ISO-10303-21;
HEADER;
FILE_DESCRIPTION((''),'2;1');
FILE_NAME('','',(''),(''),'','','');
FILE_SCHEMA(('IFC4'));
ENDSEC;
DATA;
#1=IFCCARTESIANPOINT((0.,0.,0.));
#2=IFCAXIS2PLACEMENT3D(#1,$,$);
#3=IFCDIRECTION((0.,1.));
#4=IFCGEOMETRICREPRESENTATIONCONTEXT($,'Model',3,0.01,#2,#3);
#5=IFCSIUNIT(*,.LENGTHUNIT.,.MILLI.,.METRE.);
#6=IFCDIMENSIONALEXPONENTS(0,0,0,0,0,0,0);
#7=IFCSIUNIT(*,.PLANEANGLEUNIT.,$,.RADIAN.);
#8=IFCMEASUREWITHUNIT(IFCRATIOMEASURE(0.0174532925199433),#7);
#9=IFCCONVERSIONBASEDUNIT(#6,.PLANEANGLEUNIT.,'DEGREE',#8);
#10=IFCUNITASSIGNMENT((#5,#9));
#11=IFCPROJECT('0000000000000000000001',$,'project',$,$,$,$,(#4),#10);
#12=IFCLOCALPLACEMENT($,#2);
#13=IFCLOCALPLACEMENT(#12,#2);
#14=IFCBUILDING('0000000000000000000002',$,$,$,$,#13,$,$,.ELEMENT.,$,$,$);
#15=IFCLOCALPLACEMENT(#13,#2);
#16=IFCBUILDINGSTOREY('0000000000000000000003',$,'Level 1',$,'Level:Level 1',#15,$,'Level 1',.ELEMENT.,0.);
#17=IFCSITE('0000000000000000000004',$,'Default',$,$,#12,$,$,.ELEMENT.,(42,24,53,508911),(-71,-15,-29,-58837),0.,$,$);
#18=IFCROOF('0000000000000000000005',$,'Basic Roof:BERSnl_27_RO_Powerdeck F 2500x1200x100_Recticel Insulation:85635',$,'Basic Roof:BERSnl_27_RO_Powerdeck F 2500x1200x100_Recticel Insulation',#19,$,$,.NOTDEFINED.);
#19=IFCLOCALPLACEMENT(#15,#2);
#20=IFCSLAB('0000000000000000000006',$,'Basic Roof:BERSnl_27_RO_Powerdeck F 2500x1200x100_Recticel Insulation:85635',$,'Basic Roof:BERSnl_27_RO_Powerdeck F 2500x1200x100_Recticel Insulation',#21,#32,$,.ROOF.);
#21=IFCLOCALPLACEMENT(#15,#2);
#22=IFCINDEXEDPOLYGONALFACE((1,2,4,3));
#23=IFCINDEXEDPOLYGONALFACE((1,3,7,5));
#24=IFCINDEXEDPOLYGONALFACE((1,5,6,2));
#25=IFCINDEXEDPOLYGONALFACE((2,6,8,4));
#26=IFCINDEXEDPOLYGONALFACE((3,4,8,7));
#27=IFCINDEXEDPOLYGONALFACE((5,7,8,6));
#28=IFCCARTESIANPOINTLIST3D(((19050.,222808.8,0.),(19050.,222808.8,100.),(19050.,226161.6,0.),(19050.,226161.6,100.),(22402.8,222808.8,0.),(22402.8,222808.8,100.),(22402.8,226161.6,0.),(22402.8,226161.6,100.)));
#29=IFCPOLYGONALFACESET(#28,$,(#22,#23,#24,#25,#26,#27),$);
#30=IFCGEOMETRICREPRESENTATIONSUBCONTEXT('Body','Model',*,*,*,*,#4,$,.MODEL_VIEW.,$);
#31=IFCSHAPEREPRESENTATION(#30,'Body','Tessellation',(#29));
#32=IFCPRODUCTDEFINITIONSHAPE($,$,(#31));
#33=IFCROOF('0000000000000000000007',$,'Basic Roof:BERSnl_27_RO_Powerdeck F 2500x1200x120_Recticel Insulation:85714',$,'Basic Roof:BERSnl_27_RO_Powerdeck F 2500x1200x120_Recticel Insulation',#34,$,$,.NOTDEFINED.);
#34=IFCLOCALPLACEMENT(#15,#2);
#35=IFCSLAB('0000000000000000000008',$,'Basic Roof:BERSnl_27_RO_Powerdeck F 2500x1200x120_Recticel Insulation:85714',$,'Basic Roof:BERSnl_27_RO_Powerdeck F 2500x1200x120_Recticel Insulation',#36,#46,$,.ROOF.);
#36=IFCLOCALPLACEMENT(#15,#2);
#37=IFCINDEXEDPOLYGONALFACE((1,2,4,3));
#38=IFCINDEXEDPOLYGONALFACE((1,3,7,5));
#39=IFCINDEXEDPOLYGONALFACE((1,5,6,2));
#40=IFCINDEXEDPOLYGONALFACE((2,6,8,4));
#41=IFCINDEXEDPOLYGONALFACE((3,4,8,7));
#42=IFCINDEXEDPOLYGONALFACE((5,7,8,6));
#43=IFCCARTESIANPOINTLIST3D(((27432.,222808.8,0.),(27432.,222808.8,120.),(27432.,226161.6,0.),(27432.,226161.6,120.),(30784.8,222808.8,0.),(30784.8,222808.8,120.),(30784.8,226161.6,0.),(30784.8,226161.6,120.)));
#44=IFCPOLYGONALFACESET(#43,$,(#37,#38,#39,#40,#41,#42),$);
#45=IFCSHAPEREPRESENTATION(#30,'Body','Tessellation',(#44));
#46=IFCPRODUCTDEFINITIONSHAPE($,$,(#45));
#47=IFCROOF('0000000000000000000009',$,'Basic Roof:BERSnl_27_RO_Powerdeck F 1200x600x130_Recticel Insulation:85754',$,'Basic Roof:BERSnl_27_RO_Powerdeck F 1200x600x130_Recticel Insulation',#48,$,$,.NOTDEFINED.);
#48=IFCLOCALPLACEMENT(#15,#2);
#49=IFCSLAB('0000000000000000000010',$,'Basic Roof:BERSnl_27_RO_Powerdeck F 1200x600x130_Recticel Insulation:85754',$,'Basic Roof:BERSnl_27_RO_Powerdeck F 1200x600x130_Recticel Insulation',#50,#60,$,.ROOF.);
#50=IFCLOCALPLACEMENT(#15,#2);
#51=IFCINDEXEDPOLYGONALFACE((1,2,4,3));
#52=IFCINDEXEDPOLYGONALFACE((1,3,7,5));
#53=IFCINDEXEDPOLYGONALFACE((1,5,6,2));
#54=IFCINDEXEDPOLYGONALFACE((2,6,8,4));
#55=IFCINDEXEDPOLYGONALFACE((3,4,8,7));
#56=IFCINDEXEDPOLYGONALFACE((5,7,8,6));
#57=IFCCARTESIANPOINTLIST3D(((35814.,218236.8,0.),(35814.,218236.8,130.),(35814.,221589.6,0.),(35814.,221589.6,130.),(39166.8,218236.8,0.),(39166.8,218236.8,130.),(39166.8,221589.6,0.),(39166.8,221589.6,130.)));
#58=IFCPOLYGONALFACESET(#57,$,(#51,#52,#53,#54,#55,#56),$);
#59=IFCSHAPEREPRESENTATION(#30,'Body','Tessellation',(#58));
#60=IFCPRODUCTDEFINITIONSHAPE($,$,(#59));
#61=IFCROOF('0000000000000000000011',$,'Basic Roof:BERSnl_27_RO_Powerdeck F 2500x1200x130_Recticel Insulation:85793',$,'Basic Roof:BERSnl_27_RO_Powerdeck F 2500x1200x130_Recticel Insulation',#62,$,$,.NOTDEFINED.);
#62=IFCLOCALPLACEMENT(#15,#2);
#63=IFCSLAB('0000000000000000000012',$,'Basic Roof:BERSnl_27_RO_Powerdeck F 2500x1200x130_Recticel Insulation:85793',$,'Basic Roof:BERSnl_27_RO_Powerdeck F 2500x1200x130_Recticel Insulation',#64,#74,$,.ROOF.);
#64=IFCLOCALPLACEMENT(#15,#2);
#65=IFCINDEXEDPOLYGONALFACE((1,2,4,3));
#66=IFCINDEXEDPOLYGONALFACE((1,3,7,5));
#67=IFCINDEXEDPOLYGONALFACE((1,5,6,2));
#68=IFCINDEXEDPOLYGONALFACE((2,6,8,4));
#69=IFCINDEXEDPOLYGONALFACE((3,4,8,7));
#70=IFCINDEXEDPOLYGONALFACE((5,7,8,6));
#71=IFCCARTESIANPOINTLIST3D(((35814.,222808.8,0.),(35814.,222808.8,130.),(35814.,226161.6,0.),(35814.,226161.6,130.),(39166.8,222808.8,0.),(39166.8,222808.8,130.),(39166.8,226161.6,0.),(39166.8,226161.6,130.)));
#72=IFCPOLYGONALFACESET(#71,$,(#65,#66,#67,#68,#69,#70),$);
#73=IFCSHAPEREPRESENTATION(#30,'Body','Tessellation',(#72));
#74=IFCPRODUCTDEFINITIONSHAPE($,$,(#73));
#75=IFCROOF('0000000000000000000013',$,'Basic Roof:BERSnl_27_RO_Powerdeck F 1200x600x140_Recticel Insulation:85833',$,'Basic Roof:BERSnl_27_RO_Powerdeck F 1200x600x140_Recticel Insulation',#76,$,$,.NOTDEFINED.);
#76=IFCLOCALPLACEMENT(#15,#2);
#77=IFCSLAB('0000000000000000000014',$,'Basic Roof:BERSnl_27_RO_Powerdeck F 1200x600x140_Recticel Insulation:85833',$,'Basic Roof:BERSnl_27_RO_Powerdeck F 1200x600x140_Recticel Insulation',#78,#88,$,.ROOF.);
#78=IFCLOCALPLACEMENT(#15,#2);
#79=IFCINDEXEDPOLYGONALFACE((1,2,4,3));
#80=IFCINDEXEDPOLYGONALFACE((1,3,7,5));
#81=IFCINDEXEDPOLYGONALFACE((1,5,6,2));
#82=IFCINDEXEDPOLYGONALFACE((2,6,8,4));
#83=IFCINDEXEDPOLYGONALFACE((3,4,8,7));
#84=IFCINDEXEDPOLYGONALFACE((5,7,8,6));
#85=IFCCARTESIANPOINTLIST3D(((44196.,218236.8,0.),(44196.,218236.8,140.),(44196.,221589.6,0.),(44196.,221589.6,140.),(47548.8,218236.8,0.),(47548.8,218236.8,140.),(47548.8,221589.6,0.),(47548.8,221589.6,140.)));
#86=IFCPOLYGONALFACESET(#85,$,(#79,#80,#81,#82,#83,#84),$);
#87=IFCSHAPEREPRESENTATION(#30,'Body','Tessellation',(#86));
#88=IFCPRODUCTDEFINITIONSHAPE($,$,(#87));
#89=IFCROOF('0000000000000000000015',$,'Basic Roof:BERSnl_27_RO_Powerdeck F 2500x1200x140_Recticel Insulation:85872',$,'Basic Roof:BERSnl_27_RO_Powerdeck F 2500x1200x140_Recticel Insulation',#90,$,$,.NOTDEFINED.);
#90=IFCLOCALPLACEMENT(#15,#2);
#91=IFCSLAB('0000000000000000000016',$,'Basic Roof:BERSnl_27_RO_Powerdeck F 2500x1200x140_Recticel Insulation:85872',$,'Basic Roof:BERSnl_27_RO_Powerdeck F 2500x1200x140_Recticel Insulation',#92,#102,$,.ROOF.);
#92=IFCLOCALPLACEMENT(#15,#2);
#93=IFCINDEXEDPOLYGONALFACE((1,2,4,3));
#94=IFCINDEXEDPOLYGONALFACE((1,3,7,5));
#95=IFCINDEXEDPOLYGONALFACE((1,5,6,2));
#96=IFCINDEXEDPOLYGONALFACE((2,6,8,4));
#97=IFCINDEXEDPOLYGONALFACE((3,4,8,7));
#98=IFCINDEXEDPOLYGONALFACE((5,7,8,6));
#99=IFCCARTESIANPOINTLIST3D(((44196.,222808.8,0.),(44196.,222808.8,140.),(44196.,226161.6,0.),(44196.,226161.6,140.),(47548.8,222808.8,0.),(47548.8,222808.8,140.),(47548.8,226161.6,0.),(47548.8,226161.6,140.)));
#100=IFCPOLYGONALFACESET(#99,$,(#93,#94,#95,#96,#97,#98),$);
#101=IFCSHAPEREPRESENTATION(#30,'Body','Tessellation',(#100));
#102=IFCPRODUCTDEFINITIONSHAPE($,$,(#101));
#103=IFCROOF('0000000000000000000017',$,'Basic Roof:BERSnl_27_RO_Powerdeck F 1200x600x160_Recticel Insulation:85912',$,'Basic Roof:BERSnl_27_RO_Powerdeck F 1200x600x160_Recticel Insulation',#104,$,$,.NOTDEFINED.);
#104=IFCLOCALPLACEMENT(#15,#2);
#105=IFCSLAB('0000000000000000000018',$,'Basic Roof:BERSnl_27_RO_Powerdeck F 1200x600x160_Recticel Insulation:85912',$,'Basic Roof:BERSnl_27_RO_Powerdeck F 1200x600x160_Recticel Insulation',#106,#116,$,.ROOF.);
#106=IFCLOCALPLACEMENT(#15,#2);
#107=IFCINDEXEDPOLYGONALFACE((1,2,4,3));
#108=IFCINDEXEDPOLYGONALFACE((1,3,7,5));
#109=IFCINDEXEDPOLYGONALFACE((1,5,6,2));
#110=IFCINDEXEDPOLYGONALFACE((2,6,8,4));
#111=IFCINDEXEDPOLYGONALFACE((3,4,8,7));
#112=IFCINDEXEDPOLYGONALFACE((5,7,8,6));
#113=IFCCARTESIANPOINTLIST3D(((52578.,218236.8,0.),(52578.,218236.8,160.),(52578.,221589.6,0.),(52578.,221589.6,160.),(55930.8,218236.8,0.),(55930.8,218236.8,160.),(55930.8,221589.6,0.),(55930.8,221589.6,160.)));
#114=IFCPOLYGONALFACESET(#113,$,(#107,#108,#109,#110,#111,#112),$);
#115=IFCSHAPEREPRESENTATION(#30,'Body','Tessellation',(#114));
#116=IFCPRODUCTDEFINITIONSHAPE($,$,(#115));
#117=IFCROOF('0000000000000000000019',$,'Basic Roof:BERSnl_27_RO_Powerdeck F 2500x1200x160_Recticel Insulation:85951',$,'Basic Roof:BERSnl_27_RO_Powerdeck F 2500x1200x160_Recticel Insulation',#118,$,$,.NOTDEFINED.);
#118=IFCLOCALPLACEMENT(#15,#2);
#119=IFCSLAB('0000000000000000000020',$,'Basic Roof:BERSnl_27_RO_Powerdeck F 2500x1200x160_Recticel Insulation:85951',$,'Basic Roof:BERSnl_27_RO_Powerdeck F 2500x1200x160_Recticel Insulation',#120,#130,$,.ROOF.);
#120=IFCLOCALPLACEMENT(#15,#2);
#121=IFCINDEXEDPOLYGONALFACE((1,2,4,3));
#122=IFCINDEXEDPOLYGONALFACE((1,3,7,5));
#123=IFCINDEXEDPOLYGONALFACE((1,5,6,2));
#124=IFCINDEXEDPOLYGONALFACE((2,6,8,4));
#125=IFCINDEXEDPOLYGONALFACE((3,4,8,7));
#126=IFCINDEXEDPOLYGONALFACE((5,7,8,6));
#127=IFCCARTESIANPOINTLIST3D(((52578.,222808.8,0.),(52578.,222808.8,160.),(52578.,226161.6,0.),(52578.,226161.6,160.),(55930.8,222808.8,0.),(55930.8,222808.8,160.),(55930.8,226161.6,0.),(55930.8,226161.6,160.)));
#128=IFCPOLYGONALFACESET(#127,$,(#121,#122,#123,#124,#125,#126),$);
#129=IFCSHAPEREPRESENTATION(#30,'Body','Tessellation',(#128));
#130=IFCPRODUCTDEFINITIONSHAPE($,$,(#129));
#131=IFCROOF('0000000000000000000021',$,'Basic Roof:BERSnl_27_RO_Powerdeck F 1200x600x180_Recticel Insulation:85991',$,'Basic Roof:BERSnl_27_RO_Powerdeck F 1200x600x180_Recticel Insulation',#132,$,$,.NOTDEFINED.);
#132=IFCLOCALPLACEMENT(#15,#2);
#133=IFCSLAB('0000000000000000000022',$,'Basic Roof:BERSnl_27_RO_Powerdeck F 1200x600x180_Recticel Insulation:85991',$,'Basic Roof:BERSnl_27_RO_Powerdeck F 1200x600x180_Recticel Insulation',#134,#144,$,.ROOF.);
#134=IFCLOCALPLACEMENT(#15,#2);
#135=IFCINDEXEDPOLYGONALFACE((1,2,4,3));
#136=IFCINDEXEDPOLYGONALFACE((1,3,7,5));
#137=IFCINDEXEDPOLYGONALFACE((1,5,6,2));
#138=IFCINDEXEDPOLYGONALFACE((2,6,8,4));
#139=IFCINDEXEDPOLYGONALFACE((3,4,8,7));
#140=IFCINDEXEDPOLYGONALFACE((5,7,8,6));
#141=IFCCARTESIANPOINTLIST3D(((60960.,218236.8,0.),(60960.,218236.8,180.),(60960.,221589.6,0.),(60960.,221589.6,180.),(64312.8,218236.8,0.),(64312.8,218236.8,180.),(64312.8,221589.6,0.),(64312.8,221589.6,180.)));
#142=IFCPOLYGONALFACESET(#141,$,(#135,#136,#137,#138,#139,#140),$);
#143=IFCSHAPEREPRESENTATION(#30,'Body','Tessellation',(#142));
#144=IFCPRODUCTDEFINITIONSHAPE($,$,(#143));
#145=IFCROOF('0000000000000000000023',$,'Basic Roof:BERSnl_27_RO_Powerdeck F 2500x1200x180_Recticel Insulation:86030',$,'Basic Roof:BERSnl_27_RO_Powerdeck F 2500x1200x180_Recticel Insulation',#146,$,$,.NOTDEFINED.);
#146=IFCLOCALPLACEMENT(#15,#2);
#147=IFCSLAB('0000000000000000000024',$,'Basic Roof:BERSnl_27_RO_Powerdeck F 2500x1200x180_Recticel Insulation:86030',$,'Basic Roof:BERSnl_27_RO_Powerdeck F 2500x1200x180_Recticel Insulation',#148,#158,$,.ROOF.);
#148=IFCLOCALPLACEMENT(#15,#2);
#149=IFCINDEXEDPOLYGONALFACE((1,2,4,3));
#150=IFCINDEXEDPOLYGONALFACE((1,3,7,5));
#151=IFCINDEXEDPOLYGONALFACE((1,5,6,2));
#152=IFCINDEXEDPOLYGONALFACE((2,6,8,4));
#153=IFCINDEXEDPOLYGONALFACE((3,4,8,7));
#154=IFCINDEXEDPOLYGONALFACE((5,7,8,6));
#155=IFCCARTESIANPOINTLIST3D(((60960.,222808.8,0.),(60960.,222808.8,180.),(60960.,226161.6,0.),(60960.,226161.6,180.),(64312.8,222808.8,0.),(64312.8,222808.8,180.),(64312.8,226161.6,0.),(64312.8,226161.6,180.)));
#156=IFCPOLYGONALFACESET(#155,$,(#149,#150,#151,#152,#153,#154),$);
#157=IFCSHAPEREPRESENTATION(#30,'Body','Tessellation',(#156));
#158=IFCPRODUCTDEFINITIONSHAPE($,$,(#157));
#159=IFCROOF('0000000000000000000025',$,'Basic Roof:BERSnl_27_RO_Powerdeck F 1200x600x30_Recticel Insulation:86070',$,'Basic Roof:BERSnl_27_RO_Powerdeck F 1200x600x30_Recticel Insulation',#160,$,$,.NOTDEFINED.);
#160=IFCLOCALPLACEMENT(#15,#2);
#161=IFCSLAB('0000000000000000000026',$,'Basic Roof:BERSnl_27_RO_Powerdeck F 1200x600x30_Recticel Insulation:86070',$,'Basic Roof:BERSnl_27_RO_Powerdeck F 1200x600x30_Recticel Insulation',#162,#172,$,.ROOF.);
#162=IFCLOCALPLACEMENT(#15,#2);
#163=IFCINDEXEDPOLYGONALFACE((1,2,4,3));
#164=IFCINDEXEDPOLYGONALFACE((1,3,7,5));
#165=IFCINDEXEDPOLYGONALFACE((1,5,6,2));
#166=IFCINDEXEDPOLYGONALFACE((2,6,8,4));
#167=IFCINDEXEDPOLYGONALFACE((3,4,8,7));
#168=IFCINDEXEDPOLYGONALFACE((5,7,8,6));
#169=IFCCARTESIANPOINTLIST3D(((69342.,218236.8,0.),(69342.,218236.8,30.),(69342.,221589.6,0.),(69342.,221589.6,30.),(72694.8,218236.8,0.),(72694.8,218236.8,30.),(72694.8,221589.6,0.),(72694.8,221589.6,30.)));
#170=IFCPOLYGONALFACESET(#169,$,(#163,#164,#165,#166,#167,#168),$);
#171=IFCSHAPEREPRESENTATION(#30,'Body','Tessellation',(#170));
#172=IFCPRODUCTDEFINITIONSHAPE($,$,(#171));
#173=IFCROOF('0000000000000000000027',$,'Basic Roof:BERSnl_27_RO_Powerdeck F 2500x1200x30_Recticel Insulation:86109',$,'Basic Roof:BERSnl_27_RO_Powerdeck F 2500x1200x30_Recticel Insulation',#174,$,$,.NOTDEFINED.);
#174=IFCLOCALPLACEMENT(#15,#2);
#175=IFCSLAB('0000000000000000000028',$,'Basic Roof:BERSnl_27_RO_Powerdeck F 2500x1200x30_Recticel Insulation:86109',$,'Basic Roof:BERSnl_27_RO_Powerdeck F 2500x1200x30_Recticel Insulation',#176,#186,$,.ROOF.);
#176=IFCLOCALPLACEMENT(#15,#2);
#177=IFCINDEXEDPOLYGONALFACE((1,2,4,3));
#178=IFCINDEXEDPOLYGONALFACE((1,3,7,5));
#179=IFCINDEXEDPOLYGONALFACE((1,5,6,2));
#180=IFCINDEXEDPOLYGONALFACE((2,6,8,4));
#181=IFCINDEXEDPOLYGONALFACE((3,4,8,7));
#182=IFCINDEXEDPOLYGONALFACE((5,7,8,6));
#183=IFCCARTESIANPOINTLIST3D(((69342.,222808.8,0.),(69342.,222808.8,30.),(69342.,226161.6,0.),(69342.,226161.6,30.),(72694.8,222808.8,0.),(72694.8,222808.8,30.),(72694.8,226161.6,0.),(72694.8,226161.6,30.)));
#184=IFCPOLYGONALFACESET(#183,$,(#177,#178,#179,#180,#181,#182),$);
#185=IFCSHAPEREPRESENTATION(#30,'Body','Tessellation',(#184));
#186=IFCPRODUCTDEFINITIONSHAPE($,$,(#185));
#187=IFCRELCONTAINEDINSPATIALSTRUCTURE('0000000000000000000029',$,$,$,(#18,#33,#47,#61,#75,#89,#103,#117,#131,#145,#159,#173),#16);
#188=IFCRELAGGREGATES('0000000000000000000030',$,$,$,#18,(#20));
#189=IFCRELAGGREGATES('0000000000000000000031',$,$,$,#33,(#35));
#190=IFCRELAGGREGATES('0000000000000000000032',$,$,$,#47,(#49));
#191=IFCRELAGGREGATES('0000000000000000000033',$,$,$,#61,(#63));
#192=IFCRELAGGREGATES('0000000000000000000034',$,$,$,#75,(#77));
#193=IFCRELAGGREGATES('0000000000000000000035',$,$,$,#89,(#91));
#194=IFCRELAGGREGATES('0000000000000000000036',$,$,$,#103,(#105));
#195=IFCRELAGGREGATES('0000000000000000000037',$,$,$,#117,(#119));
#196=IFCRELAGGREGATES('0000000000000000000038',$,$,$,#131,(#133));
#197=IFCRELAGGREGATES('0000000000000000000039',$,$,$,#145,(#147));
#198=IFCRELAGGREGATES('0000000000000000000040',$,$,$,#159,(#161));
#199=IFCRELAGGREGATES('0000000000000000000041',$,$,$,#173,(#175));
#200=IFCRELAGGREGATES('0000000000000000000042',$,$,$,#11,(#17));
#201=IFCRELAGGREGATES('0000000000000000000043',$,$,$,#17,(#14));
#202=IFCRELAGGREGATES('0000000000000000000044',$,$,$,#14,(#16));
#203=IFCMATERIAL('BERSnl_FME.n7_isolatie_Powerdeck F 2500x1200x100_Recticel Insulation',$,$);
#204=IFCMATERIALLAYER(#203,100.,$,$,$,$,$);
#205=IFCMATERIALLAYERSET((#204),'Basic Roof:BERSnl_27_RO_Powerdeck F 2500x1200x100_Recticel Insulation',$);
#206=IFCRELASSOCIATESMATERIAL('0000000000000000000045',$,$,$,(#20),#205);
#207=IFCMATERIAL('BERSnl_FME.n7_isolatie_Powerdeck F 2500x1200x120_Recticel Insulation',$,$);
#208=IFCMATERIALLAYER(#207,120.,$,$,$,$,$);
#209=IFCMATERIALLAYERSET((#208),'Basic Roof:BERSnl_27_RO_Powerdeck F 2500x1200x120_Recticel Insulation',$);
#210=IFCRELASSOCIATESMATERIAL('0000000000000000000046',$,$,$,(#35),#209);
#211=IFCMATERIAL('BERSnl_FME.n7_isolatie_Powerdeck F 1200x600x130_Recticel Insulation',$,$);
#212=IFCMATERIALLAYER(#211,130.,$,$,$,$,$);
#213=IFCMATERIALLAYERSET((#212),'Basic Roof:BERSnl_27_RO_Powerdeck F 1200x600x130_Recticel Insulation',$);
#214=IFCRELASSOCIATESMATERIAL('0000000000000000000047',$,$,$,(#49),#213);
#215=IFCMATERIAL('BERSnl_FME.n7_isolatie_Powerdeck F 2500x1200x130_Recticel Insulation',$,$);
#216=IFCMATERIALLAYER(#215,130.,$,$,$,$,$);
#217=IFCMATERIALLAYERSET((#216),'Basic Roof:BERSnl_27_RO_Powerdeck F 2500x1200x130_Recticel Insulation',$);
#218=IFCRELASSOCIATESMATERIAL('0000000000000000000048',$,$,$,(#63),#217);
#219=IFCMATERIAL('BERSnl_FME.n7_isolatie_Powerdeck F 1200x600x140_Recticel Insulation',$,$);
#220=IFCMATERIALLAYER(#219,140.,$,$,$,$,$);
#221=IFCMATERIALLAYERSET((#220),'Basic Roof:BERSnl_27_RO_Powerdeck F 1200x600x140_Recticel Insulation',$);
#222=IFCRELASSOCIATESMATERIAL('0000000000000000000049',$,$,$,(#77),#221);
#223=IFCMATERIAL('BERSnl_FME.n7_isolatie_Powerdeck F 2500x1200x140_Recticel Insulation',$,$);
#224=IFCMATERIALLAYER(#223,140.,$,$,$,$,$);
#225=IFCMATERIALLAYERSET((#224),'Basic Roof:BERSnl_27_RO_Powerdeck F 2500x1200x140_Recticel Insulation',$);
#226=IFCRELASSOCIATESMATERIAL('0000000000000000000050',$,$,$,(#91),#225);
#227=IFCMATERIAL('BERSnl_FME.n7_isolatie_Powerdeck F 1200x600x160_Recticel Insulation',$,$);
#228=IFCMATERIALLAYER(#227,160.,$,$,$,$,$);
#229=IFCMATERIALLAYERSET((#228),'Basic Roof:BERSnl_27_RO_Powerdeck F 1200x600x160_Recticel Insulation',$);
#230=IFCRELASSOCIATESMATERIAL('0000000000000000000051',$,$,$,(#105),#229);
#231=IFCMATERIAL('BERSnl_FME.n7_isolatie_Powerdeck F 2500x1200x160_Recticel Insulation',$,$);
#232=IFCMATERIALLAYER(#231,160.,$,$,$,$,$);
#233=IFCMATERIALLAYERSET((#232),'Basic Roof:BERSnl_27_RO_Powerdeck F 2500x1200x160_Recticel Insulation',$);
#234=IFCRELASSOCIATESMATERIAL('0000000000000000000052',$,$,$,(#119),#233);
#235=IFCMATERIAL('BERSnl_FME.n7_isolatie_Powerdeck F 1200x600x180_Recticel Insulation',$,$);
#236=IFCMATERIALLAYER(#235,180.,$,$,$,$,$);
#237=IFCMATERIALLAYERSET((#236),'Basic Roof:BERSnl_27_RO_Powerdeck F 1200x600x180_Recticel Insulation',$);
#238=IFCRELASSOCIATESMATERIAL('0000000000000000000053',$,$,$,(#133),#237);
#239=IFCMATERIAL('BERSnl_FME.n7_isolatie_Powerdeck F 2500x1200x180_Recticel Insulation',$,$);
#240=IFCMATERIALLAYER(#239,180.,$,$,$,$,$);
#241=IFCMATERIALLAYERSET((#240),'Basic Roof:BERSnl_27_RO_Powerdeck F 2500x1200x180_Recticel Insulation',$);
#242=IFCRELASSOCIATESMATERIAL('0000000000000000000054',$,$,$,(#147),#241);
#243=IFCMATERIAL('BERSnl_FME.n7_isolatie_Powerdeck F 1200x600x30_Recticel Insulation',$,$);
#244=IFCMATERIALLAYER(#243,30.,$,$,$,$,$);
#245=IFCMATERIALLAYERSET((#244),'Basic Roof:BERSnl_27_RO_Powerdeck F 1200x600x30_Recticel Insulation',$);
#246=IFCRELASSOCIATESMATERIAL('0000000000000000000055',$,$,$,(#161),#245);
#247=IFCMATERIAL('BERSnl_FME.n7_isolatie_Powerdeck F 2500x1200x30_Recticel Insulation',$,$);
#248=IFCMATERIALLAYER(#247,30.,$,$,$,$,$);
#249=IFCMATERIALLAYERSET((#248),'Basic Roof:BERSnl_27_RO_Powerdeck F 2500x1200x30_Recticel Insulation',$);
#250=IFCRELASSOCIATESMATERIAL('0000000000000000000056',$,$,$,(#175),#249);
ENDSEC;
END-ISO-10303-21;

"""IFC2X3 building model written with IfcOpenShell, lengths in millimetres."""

from ifc_helpers import new_model, entity, si_unit, converted_unit, direction, frame, frame_2d, origin, place, context, subcontext, project, spatial, rectangle, extrude, material, layer, layer_set, element, aggregate, save


model = new_model("IFC2X3")

# Units and contexts
model_context = context("Model", 3, precision=0.01, world=origin(), true_north=direction((0.0, 1.0)))
body_context = subcontext(model_context, "Body", "Model", "MODEL_VIEW")
ifc_project = project(units=[si_unit("LENGTHUNIT", "METRE", prefix="MILLI"), converted_unit("PLANEANGLEUNIT", "DEGREE", entity("IfcRatioMeasure", 0.0174532925199433), si_unit("PLANEANGLEUNIT", "RADIAN"), dimensions=[0, 0, 0, 0, 0, 0, 0])], contexts=[model_context])

# Site, building, storey
site_placement = place(None, origin())
site = spatial("IfcSite", under=ifc_project, at=site_placement, Name="Default", CompositionType="ELEMENT", RefLatitude=(42, 24, 53, 508911), RefLongitude=(-71, -15, -29, -58837), RefElevation=0.0)
building_placement = place(site_placement, origin())
building = spatial("IfcBuilding", under=site, at=building_placement, CompositionType="ELEMENT")
storey_placement = place(building_placement, origin())
storey = spatial("IfcBuildingStorey", under=building, at=storey_placement, Name="Level 1", ObjectType="Level:Level 1", LongName="Level 1", CompositionType="ELEMENT", Elevation=0.0)

# Roofs, slabs
roof_1_placement = place(storey_placement, frame((19050.0, 222808.8, 0.0)))
roof_1 = element("IfcRoof", 1, at=roof_1_placement, inside=storey, Name="Basic Roof:BERSnl_27_RO_Powerdeck F 2500x1200x100_Recticel Insulation:85635", ObjectType="Basic Roof:BERSnl_27_RO_Powerdeck F 2500x1200x100_Recticel Insulation", ShapeType="NOTDEFINED")
ifc_material_1 = material(Name="BERSnl_FME.n7_isolatie_Powerdeck F 2500x1200x100_Recticel Insulation")
ifc_layer_1 = layer(ifc_material_1, 100.0)
ifc_layer_set_1 = layer_set([ifc_layer_1], Name="Basic Roof:BERSnl_27_RO_Powerdeck F 2500x1200x100_Recticel Insulation")
slab_1_placement = place(roof_1_placement, origin())
slab_1 = element("IfcSlab", 2, at=slab_1_placement, material=ifc_layer_set_1, Name="Basic Roof:BERSnl_27_RO_Powerdeck F 2500x1200x100_Recticel Insulation:85635", ObjectType="Basic Roof:BERSnl_27_RO_Powerdeck F 2500x1200x100_Recticel Insulation", PredefinedType="ROOF", context=body_context, shape_type="SweptSolid", body=[
    extrude(rectangle(XDim=3352.8, YDim=3352.8, at=frame_2d((0.0, 0.0), x_axis=(-1.0, 0.0))), frame((1676.4, 1676.4, 0.0)), (0.0, 0.0, 1.0), 100.0),
])
aggregate(roof_1, [slab_1])
roof_2_placement = place(storey_placement, frame((27432.0, 222808.8, 0.0)))
roof_2 = element("IfcRoof", 3, at=roof_2_placement, inside=storey, Name="Basic Roof:BERSnl_27_RO_Powerdeck F 2500x1200x120_Recticel Insulation:85714", ObjectType="Basic Roof:BERSnl_27_RO_Powerdeck F 2500x1200x120_Recticel Insulation", ShapeType="NOTDEFINED")
ifc_material_2 = material(Name="BERSnl_FME.n7_isolatie_Powerdeck F 2500x1200x120_Recticel Insulation")
ifc_layer_2 = layer(ifc_material_2, 120.0)
ifc_layer_set_2 = layer_set([ifc_layer_2], Name="Basic Roof:BERSnl_27_RO_Powerdeck F 2500x1200x120_Recticel Insulation")
slab_2_placement = place(roof_2_placement, origin())
slab_2 = element("IfcSlab", 4, at=slab_2_placement, material=ifc_layer_set_2, Name="Basic Roof:BERSnl_27_RO_Powerdeck F 2500x1200x120_Recticel Insulation:85714", ObjectType="Basic Roof:BERSnl_27_RO_Powerdeck F 2500x1200x120_Recticel Insulation", PredefinedType="ROOF", context=body_context, shape_type="SweptSolid", body=[
    extrude(rectangle(XDim=3352.8, YDim=3352.8, at=frame_2d((0.0, 0.0), x_axis=(-1.0, 0.0))), frame((1676.4, 1676.4, 0.0)), (0.0, 0.0, 1.0), 120.0),
])
aggregate(roof_2, [slab_2])
roof_3_placement = place(storey_placement, frame((35814.0, 218236.8, 0.0)))
roof_3 = element("IfcRoof", 5, at=roof_3_placement, inside=storey, Name="Basic Roof:BERSnl_27_RO_Powerdeck F 1200x600x130_Recticel Insulation:85754", ObjectType="Basic Roof:BERSnl_27_RO_Powerdeck F 1200x600x130_Recticel Insulation", ShapeType="NOTDEFINED")
ifc_material_3 = material(Name="BERSnl_FME.n7_isolatie_Powerdeck F 1200x600x130_Recticel Insulation")
ifc_layer_3 = layer(ifc_material_3, 130.0)
ifc_layer_set_3 = layer_set([ifc_layer_3], Name="Basic Roof:BERSnl_27_RO_Powerdeck F 1200x600x130_Recticel Insulation")
slab_3_placement = place(roof_3_placement, origin())
slab_3 = element("IfcSlab", 6, at=slab_3_placement, material=ifc_layer_set_3, Name="Basic Roof:BERSnl_27_RO_Powerdeck F 1200x600x130_Recticel Insulation:85754", ObjectType="Basic Roof:BERSnl_27_RO_Powerdeck F 1200x600x130_Recticel Insulation", PredefinedType="ROOF", context=body_context, shape_type="SweptSolid", body=[
    extrude(rectangle(XDim=3352.8, YDim=3352.8, at=frame_2d((0.0, 0.0), x_axis=(-1.0, 0.0))), frame((1676.4, 1676.4, 0.0)), (0.0, 0.0, 1.0), 130.0),
])
aggregate(roof_3, [slab_3])
roof_4_placement = place(storey_placement, frame((35814.0, 222808.8, 0.0)))
roof_4 = element("IfcRoof", 7, at=roof_4_placement, inside=storey, Name="Basic Roof:BERSnl_27_RO_Powerdeck F 2500x1200x130_Recticel Insulation:85793", ObjectType="Basic Roof:BERSnl_27_RO_Powerdeck F 2500x1200x130_Recticel Insulation", ShapeType="NOTDEFINED")
ifc_material_4 = material(Name="BERSnl_FME.n7_isolatie_Powerdeck F 2500x1200x130_Recticel Insulation")
ifc_layer_4 = layer(ifc_material_4, 130.0)
ifc_layer_set_4 = layer_set([ifc_layer_4], Name="Basic Roof:BERSnl_27_RO_Powerdeck F 2500x1200x130_Recticel Insulation")
slab_4_placement = place(roof_4_placement, origin())
slab_4 = element("IfcSlab", 8, at=slab_4_placement, material=ifc_layer_set_4, Name="Basic Roof:BERSnl_27_RO_Powerdeck F 2500x1200x130_Recticel Insulation:85793", ObjectType="Basic Roof:BERSnl_27_RO_Powerdeck F 2500x1200x130_Recticel Insulation", PredefinedType="ROOF", context=body_context, shape_type="SweptSolid", body=[
    extrude(rectangle(XDim=3352.8, YDim=3352.8, at=frame_2d((0.0, 0.0), x_axis=(-1.0, 0.0))), frame((1676.4, 1676.4, 0.0)), (0.0, 0.0, 1.0), 130.0),
])
aggregate(roof_4, [slab_4])
roof_5_placement = place(storey_placement, frame((44196.0, 218236.8, 0.0)))
roof_5 = element("IfcRoof", 9, at=roof_5_placement, inside=storey, Name="Basic Roof:BERSnl_27_RO_Powerdeck F 1200x600x140_Recticel Insulation:85833", ObjectType="Basic Roof:BERSnl_27_RO_Powerdeck F 1200x600x140_Recticel Insulation", ShapeType="NOTDEFINED")
ifc_material_5 = material(Name="BERSnl_FME.n7_isolatie_Powerdeck F 1200x600x140_Recticel Insulation")
ifc_layer_5 = layer(ifc_material_5, 140.0)
ifc_layer_set_5 = layer_set([ifc_layer_5], Name="Basic Roof:BERSnl_27_RO_Powerdeck F 1200x600x140_Recticel Insulation")
slab_5_placement = place(roof_5_placement, origin())
slab_5 = element("IfcSlab", 10, at=slab_5_placement, material=ifc_layer_set_5, Name="Basic Roof:BERSnl_27_RO_Powerdeck F 1200x600x140_Recticel Insulation:85833", ObjectType="Basic Roof:BERSnl_27_RO_Powerdeck F 1200x600x140_Recticel Insulation", PredefinedType="ROOF", context=body_context, shape_type="SweptSolid", body=[
    extrude(rectangle(XDim=3352.8, YDim=3352.8, at=frame_2d((0.0, 0.0), x_axis=(-1.0, 0.0))), frame((1676.4, 1676.4, 0.0)), (0.0, 0.0, 1.0), 140.0),
])
aggregate(roof_5, [slab_5])
roof_6_placement = place(storey_placement, frame((44196.0, 222808.8, 0.0)))
roof_6 = element("IfcRoof", 11, at=roof_6_placement, inside=storey, Name="Basic Roof:BERSnl_27_RO_Powerdeck F 2500x1200x140_Recticel Insulation:85872", ObjectType="Basic Roof:BERSnl_27_RO_Powerdeck F 2500x1200x140_Recticel Insulation", ShapeType="NOTDEFINED")
ifc_material_6 = material(Name="BERSnl_FME.n7_isolatie_Powerdeck F 2500x1200x140_Recticel Insulation")
ifc_layer_6 = layer(ifc_material_6, 140.0)
ifc_layer_set_6 = layer_set([ifc_layer_6], Name="Basic Roof:BERSnl_27_RO_Powerdeck F 2500x1200x140_Recticel Insulation")
slab_6_placement = place(roof_6_placement, origin())
slab_6 = element("IfcSlab", 12, at=slab_6_placement, material=ifc_layer_set_6, Name="Basic Roof:BERSnl_27_RO_Powerdeck F 2500x1200x140_Recticel Insulation:85872", ObjectType="Basic Roof:BERSnl_27_RO_Powerdeck F 2500x1200x140_Recticel Insulation", PredefinedType="ROOF", context=body_context, shape_type="SweptSolid", body=[
    extrude(rectangle(XDim=3352.8, YDim=3352.8, at=frame_2d((0.0, 0.0), x_axis=(-1.0, 0.0))), frame((1676.4, 1676.4, 0.0)), (0.0, 0.0, 1.0), 140.0),
])
aggregate(roof_6, [slab_6])
roof_7_placement = place(storey_placement, frame((52578.0, 218236.8, 0.0)))
roof_7 = element("IfcRoof", 13, at=roof_7_placement, inside=storey, Name="Basic Roof:BERSnl_27_RO_Powerdeck F 1200x600x160_Recticel Insulation:85912", ObjectType="Basic Roof:BERSnl_27_RO_Powerdeck F 1200x600x160_Recticel Insulation", ShapeType="NOTDEFINED")
ifc_material_7 = material(Name="BERSnl_FME.n7_isolatie_Powerdeck F 1200x600x160_Recticel Insulation")
ifc_layer_7 = layer(ifc_material_7, 160.0)
ifc_layer_set_7 = layer_set([ifc_layer_7], Name="Basic Roof:BERSnl_27_RO_Powerdeck F 1200x600x160_Recticel Insulation")
slab_7_placement = place(roof_7_placement, origin())
slab_7 = element("IfcSlab", 14, at=slab_7_placement, material=ifc_layer_set_7, Name="Basic Roof:BERSnl_27_RO_Powerdeck F 1200x600x160_Recticel Insulation:85912", ObjectType="Basic Roof:BERSnl_27_RO_Powerdeck F 1200x600x160_Recticel Insulation", PredefinedType="ROOF", context=body_context, shape_type="SweptSolid", body=[
    extrude(rectangle(XDim=3352.8, YDim=3352.8, at=frame_2d((0.0, 0.0), x_axis=(-1.0, 0.0))), frame((1676.4, 1676.4, 0.0)), (0.0, 0.0, 1.0), 160.0),
])
aggregate(roof_7, [slab_7])
roof_8_placement = place(storey_placement, frame((52578.0, 222808.8, 0.0)))
roof_8 = element("IfcRoof", 15, at=roof_8_placement, inside=storey, Name="Basic Roof:BERSnl_27_RO_Powerdeck F 2500x1200x160_Recticel Insulation:85951", ObjectType="Basic Roof:BERSnl_27_RO_Powerdeck F 2500x1200x160_Recticel Insulation", ShapeType="NOTDEFINED")
ifc_material_8 = material(Name="BERSnl_FME.n7_isolatie_Powerdeck F 2500x1200x160_Recticel Insulation")
ifc_layer_8 = layer(ifc_material_8, 160.0)
ifc_layer_set_8 = layer_set([ifc_layer_8], Name="Basic Roof:BERSnl_27_RO_Powerdeck F 2500x1200x160_Recticel Insulation")
slab_8_placement = place(roof_8_placement, origin())
slab_8 = element("IfcSlab", 16, at=slab_8_placement, material=ifc_layer_set_8, Name="Basic Roof:BERSnl_27_RO_Powerdeck F 2500x1200x160_Recticel Insulation:85951", ObjectType="Basic Roof:BERSnl_27_RO_Powerdeck F 2500x1200x160_Recticel Insulation", PredefinedType="ROOF", context=body_context, shape_type="SweptSolid", body=[
    extrude(rectangle(XDim=3352.8, YDim=3352.8, at=frame_2d((0.0, 0.0), x_axis=(-1.0, 0.0))), frame((1676.4, 1676.4, 0.0)), (0.0, 0.0, 1.0), 160.0),
])
aggregate(roof_8, [slab_8])
roof_9_placement = place(storey_placement, frame((60960.0, 218236.8, 0.0)))
roof_9 = element("IfcRoof", 17, at=roof_9_placement, inside=storey, Name="Basic Roof:BERSnl_27_RO_Powerdeck F 1200x600x180_Recticel Insulation:85991", ObjectType="Basic Roof:BERSnl_27_RO_Powerdeck F 1200x600x180_Recticel Insulation", ShapeType="NOTDEFINED")
ifc_material_9 = material(Name="BERSnl_FME.n7_isolatie_Powerdeck F 1200x600x180_Recticel Insulation")
ifc_layer_9 = layer(ifc_material_9, 180.0)
ifc_layer_set_9 = layer_set([ifc_layer_9], Name="Basic Roof:BERSnl_27_RO_Powerdeck F 1200x600x180_Recticel Insulation")
slab_9_placement = place(roof_9_placement, origin())
slab_9 = element("IfcSlab", 18, at=slab_9_placement, material=ifc_layer_set_9, Name="Basic Roof:BERSnl_27_RO_Powerdeck F 1200x600x180_Recticel Insulation:85991", ObjectType="Basic Roof:BERSnl_27_RO_Powerdeck F 1200x600x180_Recticel Insulation", PredefinedType="ROOF", context=body_context, shape_type="SweptSolid", body=[
    extrude(rectangle(XDim=3352.8, YDim=3352.8, at=frame_2d((0.0, 0.0), x_axis=(-1.0, 0.0))), frame((1676.4, 1676.4, 0.0)), (0.0, 0.0, 1.0), 180.0),
])
aggregate(roof_9, [slab_9])
roof_10_placement = place(storey_placement, frame((60960.0, 222808.8, 0.0)))
roof_10 = element("IfcRoof", 19, at=roof_10_placement, inside=storey, Name="Basic Roof:BERSnl_27_RO_Powerdeck F 2500x1200x180_Recticel Insulation:86030", ObjectType="Basic Roof:BERSnl_27_RO_Powerdeck F 2500x1200x180_Recticel Insulation", ShapeType="NOTDEFINED")
ifc_material_10 = material(Name="BERSnl_FME.n7_isolatie_Powerdeck F 2500x1200x180_Recticel Insulation")
ifc_layer_10 = layer(ifc_material_10, 180.0)
ifc_layer_set_10 = layer_set([ifc_layer_10], Name="Basic Roof:BERSnl_27_RO_Powerdeck F 2500x1200x180_Recticel Insulation")
slab_10_placement = place(roof_10_placement, origin())
slab_10 = element("IfcSlab", 20, at=slab_10_placement, material=ifc_layer_set_10, Name="Basic Roof:BERSnl_27_RO_Powerdeck F 2500x1200x180_Recticel Insulation:86030", ObjectType="Basic Roof:BERSnl_27_RO_Powerdeck F 2500x1200x180_Recticel Insulation", PredefinedType="ROOF", context=body_context, shape_type="SweptSolid", body=[
    extrude(rectangle(XDim=3352.8, YDim=3352.8, at=frame_2d((0.0, 0.0), x_axis=(-1.0, 0.0))), frame((1676.4, 1676.4, 0.0)), (0.0, 0.0, 1.0), 180.0),
])
aggregate(roof_10, [slab_10])
roof_11_placement = place(storey_placement, frame((69342.0, 218236.8, 0.0)))
roof_11 = element("IfcRoof", 21, at=roof_11_placement, inside=storey, Name="Basic Roof:BERSnl_27_RO_Powerdeck F 1200x600x30_Recticel Insulation:86070", ObjectType="Basic Roof:BERSnl_27_RO_Powerdeck F 1200x600x30_Recticel Insulation", ShapeType="NOTDEFINED")
ifc_material_11 = material(Name="BERSnl_FME.n7_isolatie_Powerdeck F 1200x600x30_Recticel Insulation")
ifc_layer_11 = layer(ifc_material_11, 30.0)
ifc_layer_set_11 = layer_set([ifc_layer_11], Name="Basic Roof:BERSnl_27_RO_Powerdeck F 1200x600x30_Recticel Insulation")
slab_11_placement = place(roof_11_placement, origin())
slab_11 = element("IfcSlab", 22, at=slab_11_placement, material=ifc_layer_set_11, Name="Basic Roof:BERSnl_27_RO_Powerdeck F 1200x600x30_Recticel Insulation:86070", ObjectType="Basic Roof:BERSnl_27_RO_Powerdeck F 1200x600x30_Recticel Insulation", PredefinedType="ROOF", context=body_context, shape_type="SweptSolid", body=[
    extrude(rectangle(XDim=3352.8, YDim=3352.8, at=frame_2d((0.0, 0.0), x_axis=(-1.0, 0.0))), frame((1676.4, 1676.4, 0.0)), (0.0, 0.0, 1.0), 30.0),
])
aggregate(roof_11, [slab_11])
roof_12_placement = place(storey_placement, frame((69342.0, 222808.8, 0.0)))
roof_12 = element("IfcRoof", 23, at=roof_12_placement, inside=storey, Name="Basic Roof:BERSnl_27_RO_Powerdeck F 2500x1200x30_Recticel Insulation:86109", ObjectType="Basic Roof:BERSnl_27_RO_Powerdeck F 2500x1200x30_Recticel Insulation", ShapeType="NOTDEFINED")
ifc_material_12 = material(Name="BERSnl_FME.n7_isolatie_Powerdeck F 2500x1200x30_Recticel Insulation")
ifc_layer_12 = layer(ifc_material_12, 30.0)
ifc_layer_set_12 = layer_set([ifc_layer_12], Name="Basic Roof:BERSnl_27_RO_Powerdeck F 2500x1200x30_Recticel Insulation")
slab_12_placement = place(roof_12_placement, origin())
slab_12 = element("IfcSlab", 24, at=slab_12_placement, material=ifc_layer_set_12, Name="Basic Roof:BERSnl_27_RO_Powerdeck F 2500x1200x30_Recticel Insulation:86109", ObjectType="Basic Roof:BERSnl_27_RO_Powerdeck F 2500x1200x30_Recticel Insulation", PredefinedType="ROOF", context=body_context, shape_type="SweptSolid", body=[
    extrude(rectangle(XDim=3352.8, YDim=3352.8, at=frame_2d((0.0, 0.0), x_axis=(-1.0, 0.0))), frame((1676.4, 1676.4, 0.0)), (0.0, 0.0, 1.0), 30.0),
])
aggregate(roof_12, [slab_12])

save(model, "model.ifc")
